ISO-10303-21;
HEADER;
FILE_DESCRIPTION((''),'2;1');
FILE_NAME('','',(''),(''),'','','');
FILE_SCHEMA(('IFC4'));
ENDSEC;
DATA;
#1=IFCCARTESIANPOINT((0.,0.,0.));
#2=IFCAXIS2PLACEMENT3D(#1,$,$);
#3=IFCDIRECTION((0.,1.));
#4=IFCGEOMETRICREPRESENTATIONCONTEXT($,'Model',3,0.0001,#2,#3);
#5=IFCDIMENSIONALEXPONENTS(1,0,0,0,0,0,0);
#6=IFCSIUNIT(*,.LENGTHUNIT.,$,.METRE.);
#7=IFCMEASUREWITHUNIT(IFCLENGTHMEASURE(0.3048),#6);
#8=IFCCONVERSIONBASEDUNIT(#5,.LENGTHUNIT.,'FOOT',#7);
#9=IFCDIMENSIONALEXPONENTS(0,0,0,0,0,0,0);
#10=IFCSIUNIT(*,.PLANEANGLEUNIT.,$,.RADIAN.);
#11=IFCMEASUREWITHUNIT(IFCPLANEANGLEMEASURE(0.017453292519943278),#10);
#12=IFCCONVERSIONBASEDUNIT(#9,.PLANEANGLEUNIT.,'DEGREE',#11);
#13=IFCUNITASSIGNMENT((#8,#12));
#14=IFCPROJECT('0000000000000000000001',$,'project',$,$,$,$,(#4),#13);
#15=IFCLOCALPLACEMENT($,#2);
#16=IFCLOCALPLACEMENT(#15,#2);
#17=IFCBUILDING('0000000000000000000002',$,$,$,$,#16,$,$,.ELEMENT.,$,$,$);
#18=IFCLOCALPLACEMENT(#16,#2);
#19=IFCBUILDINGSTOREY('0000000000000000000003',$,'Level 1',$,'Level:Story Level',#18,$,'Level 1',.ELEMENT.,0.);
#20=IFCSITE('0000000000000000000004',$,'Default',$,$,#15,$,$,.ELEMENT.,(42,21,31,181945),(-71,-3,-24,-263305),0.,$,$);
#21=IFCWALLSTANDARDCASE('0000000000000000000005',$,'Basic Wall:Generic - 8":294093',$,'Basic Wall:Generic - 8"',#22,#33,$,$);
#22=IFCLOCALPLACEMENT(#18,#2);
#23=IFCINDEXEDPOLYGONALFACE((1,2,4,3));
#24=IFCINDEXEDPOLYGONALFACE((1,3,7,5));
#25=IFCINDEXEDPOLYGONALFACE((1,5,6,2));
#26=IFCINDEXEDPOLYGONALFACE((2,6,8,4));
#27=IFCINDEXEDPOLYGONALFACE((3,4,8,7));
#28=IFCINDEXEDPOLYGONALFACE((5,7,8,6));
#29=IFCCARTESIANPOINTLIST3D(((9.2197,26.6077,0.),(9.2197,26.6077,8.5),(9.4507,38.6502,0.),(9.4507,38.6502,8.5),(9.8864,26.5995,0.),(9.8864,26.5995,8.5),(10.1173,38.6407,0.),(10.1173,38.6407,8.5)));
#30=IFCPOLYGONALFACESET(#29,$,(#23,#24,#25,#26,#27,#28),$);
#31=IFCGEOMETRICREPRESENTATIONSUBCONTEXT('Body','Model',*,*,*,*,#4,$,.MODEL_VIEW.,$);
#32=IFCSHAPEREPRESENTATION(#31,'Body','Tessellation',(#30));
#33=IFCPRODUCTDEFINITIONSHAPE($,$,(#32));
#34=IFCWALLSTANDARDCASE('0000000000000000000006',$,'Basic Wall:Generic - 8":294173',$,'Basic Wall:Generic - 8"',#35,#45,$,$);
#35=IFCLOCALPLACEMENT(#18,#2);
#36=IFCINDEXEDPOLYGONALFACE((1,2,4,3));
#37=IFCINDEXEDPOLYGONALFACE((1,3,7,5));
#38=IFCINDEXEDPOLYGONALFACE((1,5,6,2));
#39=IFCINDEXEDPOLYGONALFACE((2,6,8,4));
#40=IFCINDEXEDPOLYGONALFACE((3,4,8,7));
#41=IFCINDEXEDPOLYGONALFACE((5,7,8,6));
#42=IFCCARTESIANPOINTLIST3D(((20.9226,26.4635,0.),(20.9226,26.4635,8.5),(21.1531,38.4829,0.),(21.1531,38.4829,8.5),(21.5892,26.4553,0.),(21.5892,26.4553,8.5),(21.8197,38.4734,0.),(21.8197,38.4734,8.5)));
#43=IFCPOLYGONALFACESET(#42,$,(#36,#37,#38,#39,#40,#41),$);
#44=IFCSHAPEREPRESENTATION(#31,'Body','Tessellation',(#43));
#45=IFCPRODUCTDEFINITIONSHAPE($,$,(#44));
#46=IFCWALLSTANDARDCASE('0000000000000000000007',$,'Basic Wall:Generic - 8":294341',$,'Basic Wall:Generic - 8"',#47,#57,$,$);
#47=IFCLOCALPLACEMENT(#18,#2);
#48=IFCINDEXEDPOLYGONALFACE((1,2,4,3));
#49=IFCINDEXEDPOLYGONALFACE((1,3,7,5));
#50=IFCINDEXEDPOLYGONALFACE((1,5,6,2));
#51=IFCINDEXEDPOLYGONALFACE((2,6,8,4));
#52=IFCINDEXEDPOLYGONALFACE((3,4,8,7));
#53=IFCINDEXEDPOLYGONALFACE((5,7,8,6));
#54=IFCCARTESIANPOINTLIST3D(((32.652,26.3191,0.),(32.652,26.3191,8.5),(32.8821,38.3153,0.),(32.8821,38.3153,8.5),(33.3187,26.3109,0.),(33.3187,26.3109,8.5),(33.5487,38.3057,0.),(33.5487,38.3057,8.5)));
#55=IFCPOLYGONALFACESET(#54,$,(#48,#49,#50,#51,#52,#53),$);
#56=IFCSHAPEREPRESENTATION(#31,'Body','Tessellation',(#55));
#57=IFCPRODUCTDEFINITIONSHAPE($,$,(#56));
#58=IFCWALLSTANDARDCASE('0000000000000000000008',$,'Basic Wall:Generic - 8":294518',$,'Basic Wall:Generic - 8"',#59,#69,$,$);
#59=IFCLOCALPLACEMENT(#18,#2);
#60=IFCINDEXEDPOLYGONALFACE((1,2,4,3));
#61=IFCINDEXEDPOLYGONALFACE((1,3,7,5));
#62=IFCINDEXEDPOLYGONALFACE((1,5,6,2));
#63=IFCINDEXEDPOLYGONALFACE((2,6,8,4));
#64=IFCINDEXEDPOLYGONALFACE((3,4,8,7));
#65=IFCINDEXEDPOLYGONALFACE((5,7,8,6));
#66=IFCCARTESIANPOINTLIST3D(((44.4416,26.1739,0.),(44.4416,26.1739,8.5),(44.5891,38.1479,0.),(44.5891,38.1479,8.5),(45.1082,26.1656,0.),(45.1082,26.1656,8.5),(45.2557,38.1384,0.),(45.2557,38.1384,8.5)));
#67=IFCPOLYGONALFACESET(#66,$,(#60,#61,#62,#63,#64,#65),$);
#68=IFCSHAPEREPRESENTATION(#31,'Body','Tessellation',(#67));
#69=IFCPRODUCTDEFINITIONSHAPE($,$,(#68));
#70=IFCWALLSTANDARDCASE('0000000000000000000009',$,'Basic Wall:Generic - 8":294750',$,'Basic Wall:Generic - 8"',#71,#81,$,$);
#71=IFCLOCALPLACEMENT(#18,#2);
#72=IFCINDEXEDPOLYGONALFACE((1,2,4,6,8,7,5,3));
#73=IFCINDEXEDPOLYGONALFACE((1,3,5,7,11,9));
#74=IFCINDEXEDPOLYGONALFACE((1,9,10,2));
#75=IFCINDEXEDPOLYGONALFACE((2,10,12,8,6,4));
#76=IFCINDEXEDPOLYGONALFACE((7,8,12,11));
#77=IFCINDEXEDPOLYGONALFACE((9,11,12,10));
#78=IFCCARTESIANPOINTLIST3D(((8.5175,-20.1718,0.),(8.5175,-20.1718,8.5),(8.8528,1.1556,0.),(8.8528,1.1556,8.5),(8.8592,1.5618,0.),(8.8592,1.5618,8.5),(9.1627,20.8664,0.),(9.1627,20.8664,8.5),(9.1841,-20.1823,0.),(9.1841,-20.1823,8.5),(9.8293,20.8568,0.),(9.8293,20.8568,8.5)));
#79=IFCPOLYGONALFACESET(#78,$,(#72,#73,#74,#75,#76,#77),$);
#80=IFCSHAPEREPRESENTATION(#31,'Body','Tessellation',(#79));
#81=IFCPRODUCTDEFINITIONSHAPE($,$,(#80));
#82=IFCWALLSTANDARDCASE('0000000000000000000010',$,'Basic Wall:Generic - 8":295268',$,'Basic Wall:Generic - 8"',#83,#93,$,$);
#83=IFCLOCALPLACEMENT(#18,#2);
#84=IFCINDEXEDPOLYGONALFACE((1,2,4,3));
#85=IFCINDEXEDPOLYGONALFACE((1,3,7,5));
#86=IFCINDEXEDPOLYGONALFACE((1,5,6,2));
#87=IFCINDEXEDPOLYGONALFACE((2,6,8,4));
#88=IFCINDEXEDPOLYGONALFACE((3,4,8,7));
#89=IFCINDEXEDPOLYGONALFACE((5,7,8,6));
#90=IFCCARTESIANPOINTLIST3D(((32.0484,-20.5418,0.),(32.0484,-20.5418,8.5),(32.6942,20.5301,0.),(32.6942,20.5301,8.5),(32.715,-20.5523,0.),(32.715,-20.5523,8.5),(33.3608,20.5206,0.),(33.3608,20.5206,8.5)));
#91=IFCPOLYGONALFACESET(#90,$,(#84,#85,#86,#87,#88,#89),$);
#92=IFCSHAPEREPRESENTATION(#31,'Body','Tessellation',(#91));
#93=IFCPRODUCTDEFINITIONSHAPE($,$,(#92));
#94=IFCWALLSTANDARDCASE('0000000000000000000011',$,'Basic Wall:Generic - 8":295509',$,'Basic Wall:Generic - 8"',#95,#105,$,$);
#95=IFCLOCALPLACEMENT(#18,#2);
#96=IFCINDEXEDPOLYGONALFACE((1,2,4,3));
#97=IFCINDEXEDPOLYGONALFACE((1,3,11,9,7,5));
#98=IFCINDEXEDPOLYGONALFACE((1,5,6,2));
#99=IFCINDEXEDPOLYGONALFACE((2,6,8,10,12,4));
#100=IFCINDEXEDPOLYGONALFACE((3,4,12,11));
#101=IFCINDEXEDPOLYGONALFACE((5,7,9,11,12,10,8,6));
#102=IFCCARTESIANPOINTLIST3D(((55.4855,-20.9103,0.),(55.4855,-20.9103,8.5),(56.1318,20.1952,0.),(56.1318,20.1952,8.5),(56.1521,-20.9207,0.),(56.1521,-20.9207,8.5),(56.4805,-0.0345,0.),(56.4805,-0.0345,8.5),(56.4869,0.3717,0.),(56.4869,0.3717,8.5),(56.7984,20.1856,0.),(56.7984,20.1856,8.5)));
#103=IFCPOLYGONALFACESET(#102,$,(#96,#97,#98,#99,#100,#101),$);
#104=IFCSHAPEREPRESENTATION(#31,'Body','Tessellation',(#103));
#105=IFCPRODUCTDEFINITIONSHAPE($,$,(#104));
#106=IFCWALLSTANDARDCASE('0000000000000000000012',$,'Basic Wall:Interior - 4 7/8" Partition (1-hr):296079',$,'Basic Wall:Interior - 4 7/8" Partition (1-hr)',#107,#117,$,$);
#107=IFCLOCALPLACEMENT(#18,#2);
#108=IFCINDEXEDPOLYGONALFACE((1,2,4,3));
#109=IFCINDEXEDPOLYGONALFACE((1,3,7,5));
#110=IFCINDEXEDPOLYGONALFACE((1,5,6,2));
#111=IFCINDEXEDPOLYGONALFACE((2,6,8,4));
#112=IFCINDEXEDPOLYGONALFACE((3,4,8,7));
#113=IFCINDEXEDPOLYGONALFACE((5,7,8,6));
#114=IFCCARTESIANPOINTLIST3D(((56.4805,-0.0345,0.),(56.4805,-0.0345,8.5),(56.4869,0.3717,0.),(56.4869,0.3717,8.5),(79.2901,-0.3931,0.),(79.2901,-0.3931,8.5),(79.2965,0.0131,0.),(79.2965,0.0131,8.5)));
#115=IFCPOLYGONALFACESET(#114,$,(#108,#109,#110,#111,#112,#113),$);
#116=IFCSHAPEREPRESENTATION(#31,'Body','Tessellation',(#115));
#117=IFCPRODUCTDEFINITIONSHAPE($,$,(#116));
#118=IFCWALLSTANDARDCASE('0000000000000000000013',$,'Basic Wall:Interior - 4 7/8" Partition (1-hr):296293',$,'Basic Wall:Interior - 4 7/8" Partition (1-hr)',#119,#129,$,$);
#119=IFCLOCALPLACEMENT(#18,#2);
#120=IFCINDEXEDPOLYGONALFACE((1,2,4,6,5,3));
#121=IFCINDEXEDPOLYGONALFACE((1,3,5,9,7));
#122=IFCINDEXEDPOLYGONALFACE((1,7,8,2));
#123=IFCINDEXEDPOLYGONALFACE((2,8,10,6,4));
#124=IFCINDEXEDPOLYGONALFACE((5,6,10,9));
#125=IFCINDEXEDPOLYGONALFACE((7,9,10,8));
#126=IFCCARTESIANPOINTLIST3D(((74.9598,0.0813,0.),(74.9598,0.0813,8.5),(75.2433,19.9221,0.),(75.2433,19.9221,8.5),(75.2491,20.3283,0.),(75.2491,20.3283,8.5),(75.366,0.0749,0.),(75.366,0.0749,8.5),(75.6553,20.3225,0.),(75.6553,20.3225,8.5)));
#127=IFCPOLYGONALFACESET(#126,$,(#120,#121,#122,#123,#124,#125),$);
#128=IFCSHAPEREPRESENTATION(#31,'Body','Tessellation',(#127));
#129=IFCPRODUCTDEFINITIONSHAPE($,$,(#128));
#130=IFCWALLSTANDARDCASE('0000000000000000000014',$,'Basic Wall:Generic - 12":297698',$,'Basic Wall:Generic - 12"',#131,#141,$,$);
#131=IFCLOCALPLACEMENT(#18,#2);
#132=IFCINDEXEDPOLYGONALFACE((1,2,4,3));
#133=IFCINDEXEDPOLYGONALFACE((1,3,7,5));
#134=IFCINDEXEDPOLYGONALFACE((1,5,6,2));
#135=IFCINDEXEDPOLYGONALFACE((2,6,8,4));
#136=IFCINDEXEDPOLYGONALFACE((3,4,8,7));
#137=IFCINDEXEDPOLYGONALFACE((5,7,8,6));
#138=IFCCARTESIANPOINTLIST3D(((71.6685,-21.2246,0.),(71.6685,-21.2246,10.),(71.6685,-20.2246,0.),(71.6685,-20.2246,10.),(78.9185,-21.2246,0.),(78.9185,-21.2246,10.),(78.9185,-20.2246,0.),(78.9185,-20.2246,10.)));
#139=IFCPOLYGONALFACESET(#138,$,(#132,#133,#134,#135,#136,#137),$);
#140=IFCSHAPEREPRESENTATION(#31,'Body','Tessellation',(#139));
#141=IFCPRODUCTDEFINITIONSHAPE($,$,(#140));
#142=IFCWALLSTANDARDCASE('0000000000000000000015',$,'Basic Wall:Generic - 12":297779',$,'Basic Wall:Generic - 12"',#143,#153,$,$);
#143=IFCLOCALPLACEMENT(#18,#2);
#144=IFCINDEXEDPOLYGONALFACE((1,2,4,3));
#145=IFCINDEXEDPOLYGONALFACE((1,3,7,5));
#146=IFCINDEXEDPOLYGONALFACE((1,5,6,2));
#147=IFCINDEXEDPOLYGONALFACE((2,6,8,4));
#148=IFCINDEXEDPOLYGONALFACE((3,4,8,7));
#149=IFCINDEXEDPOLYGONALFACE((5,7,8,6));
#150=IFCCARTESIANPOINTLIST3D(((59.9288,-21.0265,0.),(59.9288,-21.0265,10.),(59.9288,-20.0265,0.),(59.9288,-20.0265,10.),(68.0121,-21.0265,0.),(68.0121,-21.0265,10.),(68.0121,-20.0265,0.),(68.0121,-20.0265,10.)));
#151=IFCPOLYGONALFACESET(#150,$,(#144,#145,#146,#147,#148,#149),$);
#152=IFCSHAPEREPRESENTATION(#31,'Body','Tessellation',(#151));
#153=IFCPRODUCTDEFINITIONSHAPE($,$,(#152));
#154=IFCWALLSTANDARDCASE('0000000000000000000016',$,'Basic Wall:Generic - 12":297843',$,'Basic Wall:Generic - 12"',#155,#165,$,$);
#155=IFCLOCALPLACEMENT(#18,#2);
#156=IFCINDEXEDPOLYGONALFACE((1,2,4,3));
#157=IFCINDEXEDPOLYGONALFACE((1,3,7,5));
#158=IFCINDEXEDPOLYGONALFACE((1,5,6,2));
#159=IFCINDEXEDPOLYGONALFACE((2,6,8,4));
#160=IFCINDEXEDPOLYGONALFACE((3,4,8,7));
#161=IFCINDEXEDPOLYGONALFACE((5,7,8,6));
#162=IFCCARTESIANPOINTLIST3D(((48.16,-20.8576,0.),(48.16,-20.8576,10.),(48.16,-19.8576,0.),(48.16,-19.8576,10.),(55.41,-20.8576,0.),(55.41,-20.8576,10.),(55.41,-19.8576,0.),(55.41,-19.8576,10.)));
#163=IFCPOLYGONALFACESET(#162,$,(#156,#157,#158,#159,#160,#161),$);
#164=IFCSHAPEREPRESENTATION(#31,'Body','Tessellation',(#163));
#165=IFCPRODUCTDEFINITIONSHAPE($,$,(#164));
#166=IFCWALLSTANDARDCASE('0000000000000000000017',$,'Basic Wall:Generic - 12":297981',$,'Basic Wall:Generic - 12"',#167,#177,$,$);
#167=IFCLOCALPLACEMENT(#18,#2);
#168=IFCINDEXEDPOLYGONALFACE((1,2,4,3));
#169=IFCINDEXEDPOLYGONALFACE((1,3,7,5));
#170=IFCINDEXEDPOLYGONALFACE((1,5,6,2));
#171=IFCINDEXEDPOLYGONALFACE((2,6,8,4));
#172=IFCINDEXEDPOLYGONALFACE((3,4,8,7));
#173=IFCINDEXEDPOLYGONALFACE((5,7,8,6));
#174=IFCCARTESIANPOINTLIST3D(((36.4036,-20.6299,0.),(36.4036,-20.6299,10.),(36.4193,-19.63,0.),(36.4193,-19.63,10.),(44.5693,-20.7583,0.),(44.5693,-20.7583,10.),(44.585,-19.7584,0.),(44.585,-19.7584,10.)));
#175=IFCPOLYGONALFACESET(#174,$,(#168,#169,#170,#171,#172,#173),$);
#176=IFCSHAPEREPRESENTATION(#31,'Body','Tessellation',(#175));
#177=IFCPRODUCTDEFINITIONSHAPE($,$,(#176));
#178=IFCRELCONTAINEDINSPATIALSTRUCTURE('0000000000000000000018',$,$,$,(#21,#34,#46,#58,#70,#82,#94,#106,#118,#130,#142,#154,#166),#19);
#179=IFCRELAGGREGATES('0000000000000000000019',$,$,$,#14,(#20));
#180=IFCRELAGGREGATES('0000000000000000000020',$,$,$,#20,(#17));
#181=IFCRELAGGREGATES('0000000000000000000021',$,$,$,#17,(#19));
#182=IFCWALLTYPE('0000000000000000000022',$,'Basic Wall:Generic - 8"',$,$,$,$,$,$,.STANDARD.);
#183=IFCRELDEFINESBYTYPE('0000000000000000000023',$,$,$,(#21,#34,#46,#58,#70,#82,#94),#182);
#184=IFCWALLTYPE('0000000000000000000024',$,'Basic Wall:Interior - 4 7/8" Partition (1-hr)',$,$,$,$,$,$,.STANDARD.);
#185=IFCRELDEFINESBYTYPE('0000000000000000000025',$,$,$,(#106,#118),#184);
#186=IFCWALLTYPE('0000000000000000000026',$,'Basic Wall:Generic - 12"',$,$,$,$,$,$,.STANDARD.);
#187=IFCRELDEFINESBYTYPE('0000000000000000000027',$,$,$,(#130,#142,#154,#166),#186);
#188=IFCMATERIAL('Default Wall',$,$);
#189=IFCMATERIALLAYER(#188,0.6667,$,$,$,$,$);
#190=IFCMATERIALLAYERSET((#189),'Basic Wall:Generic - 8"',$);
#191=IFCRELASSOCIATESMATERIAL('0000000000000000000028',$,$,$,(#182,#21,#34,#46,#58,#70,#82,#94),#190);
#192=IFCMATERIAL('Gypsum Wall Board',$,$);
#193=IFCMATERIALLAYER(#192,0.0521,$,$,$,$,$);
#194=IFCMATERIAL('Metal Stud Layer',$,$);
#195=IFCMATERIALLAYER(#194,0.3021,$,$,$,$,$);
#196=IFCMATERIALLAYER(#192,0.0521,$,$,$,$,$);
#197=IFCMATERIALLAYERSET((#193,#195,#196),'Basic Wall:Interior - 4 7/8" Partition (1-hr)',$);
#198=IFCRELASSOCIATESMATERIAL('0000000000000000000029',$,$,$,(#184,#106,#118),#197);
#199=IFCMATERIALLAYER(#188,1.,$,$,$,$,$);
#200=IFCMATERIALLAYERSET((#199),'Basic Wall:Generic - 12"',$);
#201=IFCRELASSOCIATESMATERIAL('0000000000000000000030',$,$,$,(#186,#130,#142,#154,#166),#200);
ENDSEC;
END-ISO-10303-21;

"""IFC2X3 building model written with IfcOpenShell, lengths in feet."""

from ifc_helpers import new_model, entity, si_unit, converted_unit, direction, frame, frame_2d, origin, place, context, subcontext, project, spatial, polyline, rectangle, outline, extrude, material, layer, layer_set, layer_usage, type_object, element, save


model = new_model("IFC2X3")

# Units and contexts
model_context = context("Model", 3, precision=0.0001, world=origin(), true_north=direction((0.0, 1.0)))
body_context = subcontext(model_context, "Body", "Model", "MODEL_VIEW")
ifc_project = project(units=[converted_unit("LENGTHUNIT", "FOOT", entity("IfcLengthMeasure", 0.3048), si_unit("LENGTHUNIT", "METRE"), dimensions=[1, 0, 0, 0, 0, 0, 0]), converted_unit("PLANEANGLEUNIT", "DEGREE", entity("IfcPlaneAngleMeasure", 0.017453292519943278), si_unit("PLANEANGLEUNIT", "RADIAN"), dimensions=[0, 0, 0, 0, 0, 0, 0])], contexts=[model_context])

# Site, building, storey
site_placement = place(None, origin())
site = spatial("IfcSite", under=ifc_project, at=site_placement, Name="Default", CompositionType="ELEMENT", RefLatitude=(42, 21, 31, 181945), RefLongitude=(-71, -3, -24, -263305), RefElevation=0.0)
building_placement = place(site_placement, origin())
building = spatial("IfcBuilding", under=site, at=building_placement, CompositionType="ELEMENT")
storey_placement = place(building_placement, origin())
storey = spatial("IfcBuildingStorey", under=building, at=storey_placement, Name="Level 1", ObjectType="Level:Story Level", LongName="Level 1", CompositionType="ELEMENT", Elevation=0.0)

# Walls
ifc_material_1 = material(Name="Default Wall")
ifc_layer_1 = layer(ifc_material_1, 0.6667)
ifc_layer_set_1 = layer_set([ifc_layer_1], Name="Basic Wall:Generic - 8\"")
ifc_layer_usage_1 = layer_usage(ifc_layer_set_1, "AXIS2", "NEGATIVE", 0.3333)
wall_type_1 = type_object("IfcWallType", Name="Basic Wall:Generic - 8\"", PredefinedType="STANDARD", material=ifc_layer_set_1)
wall_1_placement = place(storey_placement, frame((9.7841, 38.647, 0.0), z_axis=(0.0, 0.0, 1.0), x_axis=(-0.019177, -0.999816, 0.0)))
element("IfcWallStandardCase", 1, at=wall_1_placement, inside=storey, type_object=wall_type_1, material=ifc_layer_usage_1, Name="Basic Wall:Generic - 8\":294093", ObjectType="Basic Wall:Generic - 8\"", context=body_context, shape_type="SweptSolid", body=[
    extrude(outline(polyline([(12.048, -0.3333), (12.0434, 0.3333), (0.0, 0.3333), (0.0033, -0.3333), (12.048, -0.3333)])), origin(), (0.0, 0.0, 1.0), 8.5),
])
ifc_layer_usage_2 = layer_usage(ifc_layer_set_1, "AXIS2", "NEGATIVE", 0.3333)
wall_2_placement = place(storey_placement, frame((21.4864, 38.4798, 0.0), z_axis=(0.0, 0.0, 1.0), x_axis=(-0.019177, -0.999816, 0.0)))
element("IfcWallStandardCase", 2, at=wall_2_placement, inside=storey, type_object=wall_type_1, material=ifc_layer_usage_2, Name="Basic Wall:Generic - 8\":294173", ObjectType="Basic Wall:Generic - 8\"", context=body_context, shape_type="SweptSolid", body=[
    extrude(outline(polyline([(12.0248, -0.3333), (12.0203, 0.3333), (0.0, 0.3333), (0.0033, -0.3333), (12.0248, -0.3333)])), origin(), (0.0, 0.0, 1.0), 8.5),
])
ifc_layer_usage_3 = layer_usage(ifc_layer_set_1, "AXIS2", "NEGATIVE", 0.3333)
wall_3_placement = place(storey_placement, frame((33.2155, 38.3121, 0.0), z_axis=(0.0, 0.0, 1.0), x_axis=(-0.019177, -0.999816, 0.0)))
element("IfcWallStandardCase", 3, at=wall_3_placement, inside=storey, type_object=wall_type_1, material=ifc_layer_usage_3, Name="Basic Wall:Generic - 8\":294341", ObjectType="Basic Wall:Generic - 8\"", context=body_context, shape_type="SweptSolid", body=[
    extrude(outline(polyline([(12.0017, -0.3333), (11.9971, 0.3333), (0.0, 0.3333), (0.0033, -0.3333), (12.0017, -0.3333)])), origin(), (0.0, 0.0, 1.0), 8.5),
])
ifc_layer_usage_4 = layer_usage(ifc_layer_set_1, "AXIS2", "NEGATIVE", 0.3333)
wall_4_placement = place(storey_placement, frame((44.9224, 38.1438, 0.0), z_axis=(0.0, 0.0, 1.0), x_axis=(-0.012316, -0.999924, 0.0)))
element("IfcWallStandardCase", 4, at=wall_4_placement, inside=storey, type_object=wall_type_1, material=ifc_layer_usage_4, Name="Basic Wall:Generic - 8\":294518", ObjectType="Basic Wall:Generic - 8\"", context=body_context, shape_type="SweptSolid", body=[
    extrude(outline(polyline([(11.975, -0.3333), (11.975, 0.3333), (0.0013, 0.3333), (0.0, -0.3333), (11.975, -0.3333)])), origin(), (0.0, 0.0, 1.0), 8.5),
])
ifc_layer_usage_5 = layer_usage(ifc_layer_set_1, "AXIS2", "NEGATIVE", 0.3333)
wall_5_placement = place(storey_placement, frame((9.496, 20.8621, 0.0), z_axis=(0.0, 0.0, 1.0), x_axis=(-0.015721, -0.999876, 0.0)))
element("IfcWallStandardCase", 5, at=wall_5_placement, inside=storey, type_object=wall_type_1, material=ifc_layer_usage_5, Name="Basic Wall:Generic - 8\":294750", ObjectType="Basic Wall:Generic - 8\"", context=body_context, shape_type="SweptSolid", body=[
    extrude(outline(polyline([(41.0442, -0.3333), (41.0442, 0.3333), (0.0, 0.3333), (0.001, -0.3333), (19.3079, -0.3333), (19.7141, -0.3333), (41.0442, -0.3333)])), origin(), (0.0, 0.0, 1.0), 8.5),
])
ifc_layer_usage_6 = layer_usage(ifc_layer_set_1, "AXIS2", "NEGATIVE", 0.3333)
wall_6_placement = place(storey_placement, frame((33.0275, 20.5258, 0.0), z_axis=(0.0, 0.0, 1.0), x_axis=(-0.015721, -0.999876, 0.0)))
element("IfcWallStandardCase", 6, at=wall_6_placement, inside=storey, type_object=wall_type_1, material=ifc_layer_usage_6, Name="Basic Wall:Generic - 8\":295268", ObjectType="Basic Wall:Generic - 8\"", context=body_context, shape_type="SweptSolid", body=[
    extrude(outline(polyline([(41.0779, -0.3333), (41.0779, 0.3333), (0.0, 0.3333), (0.001, -0.3333), (41.0779, -0.3333)])), origin(), (0.0, 0.0, 1.0), 8.5),
])
ifc_layer_usage_7 = layer_usage(ifc_layer_set_1, "AXIS2", "NEGATIVE", 0.3333)
wall_7_placement = place(storey_placement, frame((56.4651, 20.1909, 0.0), z_axis=(0.0, 0.0, 1.0), x_axis=(-0.015721, -0.999876, 0.0)))
element("IfcWallStandardCase", 7, at=wall_7_placement, inside=storey, type_object=wall_type_1, material=ifc_layer_usage_7, Name="Basic Wall:Generic - 8\":295509", ObjectType="Basic Wall:Generic - 8\"", context=body_context, shape_type="SweptSolid", body=[
    extrude(outline(polyline([(41.1115, -0.3333), (41.1115, 0.3333), (20.2226, 0.3333), (19.8164, 0.3333), (0.0, 0.3333), (0.001, -0.3333), (41.1115, -0.3333)])), origin(), (0.0, 0.0, 1.0), 8.5),
])
ifc_material_2 = material(Name="Gypsum Wall Board")
ifc_layer_2 = layer(ifc_material_2, 0.0521)
ifc_material_3 = material(Name="Metal Stud Layer")
ifc_layer_3 = layer(ifc_material_3, 0.3021)
ifc_layer_4 = layer(ifc_material_2, 0.0521)
ifc_layer_set_2 = layer_set([ifc_layer_2, ifc_layer_3, ifc_layer_4], Name="Basic Wall:Interior - 4 7/8\" Partition (1-hr)")
ifc_layer_usage_8 = layer_usage(ifc_layer_set_2, "AXIS2", "NEGATIVE", 0.2031)
wall_type_2 = type_object("IfcWallType", Name="Basic Wall:Interior - 4 7/8\" Partition (1-hr)", PredefinedType="STANDARD", material=ifc_layer_set_2)
wall_8_placement = place(storey_placement, frame((79.2933, -0.19, 0.0), z_axis=(0.0, 0.0, 1.0), x_axis=(-0.999876, 0.015721, 0.0)))
element("IfcWallStandardCase", 8, at=wall_8_placement, inside=storey, type_object=wall_type_2, material=ifc_layer_usage_8, Name="Basic Wall:Interior - 4 7/8\" Partition (1-hr):296079", ObjectType="Basic Wall:Interior - 4 7/8\" Partition (1-hr)", context=body_context, shape_type="SweptSolid", body=[
    extrude(rectangle(XDim=22.8124, YDim=0.4063, at=frame_2d((11.4062, 0.0), x_axis=(-1.0, 0.0))), origin(), (0.0, 0.0, 1.0), 8.5),
])
ifc_layer_usage_9 = layer_usage(ifc_layer_set_2, "AXIS2", "NEGATIVE", 0.2031)
wall_9_placement = place(storey_placement, frame((75.1628, 0.0778, 0.0), z_axis=(0.0, 0.0, 1.0), x_axis=(0.014289, 0.999898, 0.0)))
element("IfcWallStandardCase", 9, at=wall_9_placement, inside=storey, type_object=wall_type_2, material=ifc_layer_usage_9, Name="Basic Wall:Interior - 4 7/8\" Partition (1-hr):296293", ObjectType="Basic Wall:Interior - 4 7/8\" Partition (1-hr)", context=body_context, shape_type="SweptSolid", body=[
    extrude(outline(polyline([(20.2496, -0.2031), (20.2496, 0.2031), (19.8434, 0.2031), (0.0006, 0.2031), (0.0, -0.2031), (20.2496, -0.2031)])), origin(), (0.0, 0.0, 1.0), 8.5),
])

# Walls
ifc_layer_5 = layer(ifc_material_1, 1.0)
ifc_layer_set_3 = layer_set([ifc_layer_5], Name="Basic Wall:Generic - 12\"")
ifc_layer_usage_10 = layer_usage(ifc_layer_set_3, "AXIS2", "NEGATIVE", 0.5)
wall_type_3 = type_object("IfcWallType", Name="Basic Wall:Generic - 12\"", PredefinedType="STANDARD", material=ifc_layer_set_3)
wall_10_placement = place(storey_placement, frame((78.9185, -20.7246, 0.0), z_axis=(0.0, 0.0, 1.0), x_axis=(-1.0, 0.0, 0.0)))
element("IfcWallStandardCase", 10, at=wall_10_placement, inside=storey, type_object=wall_type_3, material=ifc_layer_usage_10, Name="Basic Wall:Generic - 12\":297698", ObjectType="Basic Wall:Generic - 12\"", context=body_context, shape_type="SweptSolid", body=[
    extrude(rectangle(XDim=7.25, YDim=1.0, at=frame_2d((3.625, 0.0), x_axis=(-1.0, 0.0))), origin(), (0.0, 0.0, 1.0), 10.0),
])
ifc_layer_usage_11 = layer_usage(ifc_layer_set_3, "AXIS2", "NEGATIVE", 0.5)
wall_11_placement = place(storey_placement, frame((68.0121, -20.5265, 0.0), z_axis=(0.0, 0.0, 1.0), x_axis=(-1.0, 0.0, 0.0)))
element("IfcWallStandardCase", 11, at=wall_11_placement, inside=storey, type_object=wall_type_3, material=ifc_layer_usage_11, Name="Basic Wall:Generic - 12\":297779", ObjectType="Basic Wall:Generic - 12\"", context=body_context, shape_type="SweptSolid", body=[
    extrude(rectangle(XDim=8.0833, YDim=1.0, at=frame_2d((4.0417, 0.0), x_axis=(-1.0, 0.0))), origin(), (0.0, 0.0, 1.0), 10.0),
])
ifc_layer_usage_12 = layer_usage(ifc_layer_set_3, "AXIS2", "NEGATIVE", 0.5)
wall_12_placement = place(storey_placement, frame((55.41, -20.3576, 0.0), z_axis=(0.0, 0.0, 1.0), x_axis=(-1.0, 0.0, 0.0)))
element("IfcWallStandardCase", 12, at=wall_12_placement, inside=storey, type_object=wall_type_3, material=ifc_layer_usage_12, Name="Basic Wall:Generic - 12\":297843", ObjectType="Basic Wall:Generic - 12\"", context=body_context, shape_type="SweptSolid", body=[
    extrude(rectangle(XDim=7.25, YDim=1.0, at=frame_2d((3.625, 0.0), x_axis=(-1.0, 0.0))), origin(), (0.0, 0.0, 1.0), 10.0),
])
ifc_layer_usage_13 = layer_usage(ifc_layer_set_3, "AXIS2", "NEGATIVE", 0.5)
wall_13_placement = place(storey_placement, frame((44.5771, -20.2583, 0.0), z_axis=(0.0, 0.0, 1.0), x_axis=(-0.999876, 0.015721, 0.0)))
element("IfcWallStandardCase", 13, at=wall_13_placement, inside=storey, type_object=wall_type_3, material=ifc_layer_usage_13, Name="Basic Wall:Generic - 12\":297981", ObjectType="Basic Wall:Generic - 12\"", context=body_context, shape_type="SweptSolid", body=[
    extrude(rectangle(XDim=8.1667, YDim=1.0, at=frame_2d((4.0833, 0.0), x_axis=(-1.0, 0.0))), origin(), (0.0, 0.0, 1.0), 10.0),
])

save(model, "model.ifc")
